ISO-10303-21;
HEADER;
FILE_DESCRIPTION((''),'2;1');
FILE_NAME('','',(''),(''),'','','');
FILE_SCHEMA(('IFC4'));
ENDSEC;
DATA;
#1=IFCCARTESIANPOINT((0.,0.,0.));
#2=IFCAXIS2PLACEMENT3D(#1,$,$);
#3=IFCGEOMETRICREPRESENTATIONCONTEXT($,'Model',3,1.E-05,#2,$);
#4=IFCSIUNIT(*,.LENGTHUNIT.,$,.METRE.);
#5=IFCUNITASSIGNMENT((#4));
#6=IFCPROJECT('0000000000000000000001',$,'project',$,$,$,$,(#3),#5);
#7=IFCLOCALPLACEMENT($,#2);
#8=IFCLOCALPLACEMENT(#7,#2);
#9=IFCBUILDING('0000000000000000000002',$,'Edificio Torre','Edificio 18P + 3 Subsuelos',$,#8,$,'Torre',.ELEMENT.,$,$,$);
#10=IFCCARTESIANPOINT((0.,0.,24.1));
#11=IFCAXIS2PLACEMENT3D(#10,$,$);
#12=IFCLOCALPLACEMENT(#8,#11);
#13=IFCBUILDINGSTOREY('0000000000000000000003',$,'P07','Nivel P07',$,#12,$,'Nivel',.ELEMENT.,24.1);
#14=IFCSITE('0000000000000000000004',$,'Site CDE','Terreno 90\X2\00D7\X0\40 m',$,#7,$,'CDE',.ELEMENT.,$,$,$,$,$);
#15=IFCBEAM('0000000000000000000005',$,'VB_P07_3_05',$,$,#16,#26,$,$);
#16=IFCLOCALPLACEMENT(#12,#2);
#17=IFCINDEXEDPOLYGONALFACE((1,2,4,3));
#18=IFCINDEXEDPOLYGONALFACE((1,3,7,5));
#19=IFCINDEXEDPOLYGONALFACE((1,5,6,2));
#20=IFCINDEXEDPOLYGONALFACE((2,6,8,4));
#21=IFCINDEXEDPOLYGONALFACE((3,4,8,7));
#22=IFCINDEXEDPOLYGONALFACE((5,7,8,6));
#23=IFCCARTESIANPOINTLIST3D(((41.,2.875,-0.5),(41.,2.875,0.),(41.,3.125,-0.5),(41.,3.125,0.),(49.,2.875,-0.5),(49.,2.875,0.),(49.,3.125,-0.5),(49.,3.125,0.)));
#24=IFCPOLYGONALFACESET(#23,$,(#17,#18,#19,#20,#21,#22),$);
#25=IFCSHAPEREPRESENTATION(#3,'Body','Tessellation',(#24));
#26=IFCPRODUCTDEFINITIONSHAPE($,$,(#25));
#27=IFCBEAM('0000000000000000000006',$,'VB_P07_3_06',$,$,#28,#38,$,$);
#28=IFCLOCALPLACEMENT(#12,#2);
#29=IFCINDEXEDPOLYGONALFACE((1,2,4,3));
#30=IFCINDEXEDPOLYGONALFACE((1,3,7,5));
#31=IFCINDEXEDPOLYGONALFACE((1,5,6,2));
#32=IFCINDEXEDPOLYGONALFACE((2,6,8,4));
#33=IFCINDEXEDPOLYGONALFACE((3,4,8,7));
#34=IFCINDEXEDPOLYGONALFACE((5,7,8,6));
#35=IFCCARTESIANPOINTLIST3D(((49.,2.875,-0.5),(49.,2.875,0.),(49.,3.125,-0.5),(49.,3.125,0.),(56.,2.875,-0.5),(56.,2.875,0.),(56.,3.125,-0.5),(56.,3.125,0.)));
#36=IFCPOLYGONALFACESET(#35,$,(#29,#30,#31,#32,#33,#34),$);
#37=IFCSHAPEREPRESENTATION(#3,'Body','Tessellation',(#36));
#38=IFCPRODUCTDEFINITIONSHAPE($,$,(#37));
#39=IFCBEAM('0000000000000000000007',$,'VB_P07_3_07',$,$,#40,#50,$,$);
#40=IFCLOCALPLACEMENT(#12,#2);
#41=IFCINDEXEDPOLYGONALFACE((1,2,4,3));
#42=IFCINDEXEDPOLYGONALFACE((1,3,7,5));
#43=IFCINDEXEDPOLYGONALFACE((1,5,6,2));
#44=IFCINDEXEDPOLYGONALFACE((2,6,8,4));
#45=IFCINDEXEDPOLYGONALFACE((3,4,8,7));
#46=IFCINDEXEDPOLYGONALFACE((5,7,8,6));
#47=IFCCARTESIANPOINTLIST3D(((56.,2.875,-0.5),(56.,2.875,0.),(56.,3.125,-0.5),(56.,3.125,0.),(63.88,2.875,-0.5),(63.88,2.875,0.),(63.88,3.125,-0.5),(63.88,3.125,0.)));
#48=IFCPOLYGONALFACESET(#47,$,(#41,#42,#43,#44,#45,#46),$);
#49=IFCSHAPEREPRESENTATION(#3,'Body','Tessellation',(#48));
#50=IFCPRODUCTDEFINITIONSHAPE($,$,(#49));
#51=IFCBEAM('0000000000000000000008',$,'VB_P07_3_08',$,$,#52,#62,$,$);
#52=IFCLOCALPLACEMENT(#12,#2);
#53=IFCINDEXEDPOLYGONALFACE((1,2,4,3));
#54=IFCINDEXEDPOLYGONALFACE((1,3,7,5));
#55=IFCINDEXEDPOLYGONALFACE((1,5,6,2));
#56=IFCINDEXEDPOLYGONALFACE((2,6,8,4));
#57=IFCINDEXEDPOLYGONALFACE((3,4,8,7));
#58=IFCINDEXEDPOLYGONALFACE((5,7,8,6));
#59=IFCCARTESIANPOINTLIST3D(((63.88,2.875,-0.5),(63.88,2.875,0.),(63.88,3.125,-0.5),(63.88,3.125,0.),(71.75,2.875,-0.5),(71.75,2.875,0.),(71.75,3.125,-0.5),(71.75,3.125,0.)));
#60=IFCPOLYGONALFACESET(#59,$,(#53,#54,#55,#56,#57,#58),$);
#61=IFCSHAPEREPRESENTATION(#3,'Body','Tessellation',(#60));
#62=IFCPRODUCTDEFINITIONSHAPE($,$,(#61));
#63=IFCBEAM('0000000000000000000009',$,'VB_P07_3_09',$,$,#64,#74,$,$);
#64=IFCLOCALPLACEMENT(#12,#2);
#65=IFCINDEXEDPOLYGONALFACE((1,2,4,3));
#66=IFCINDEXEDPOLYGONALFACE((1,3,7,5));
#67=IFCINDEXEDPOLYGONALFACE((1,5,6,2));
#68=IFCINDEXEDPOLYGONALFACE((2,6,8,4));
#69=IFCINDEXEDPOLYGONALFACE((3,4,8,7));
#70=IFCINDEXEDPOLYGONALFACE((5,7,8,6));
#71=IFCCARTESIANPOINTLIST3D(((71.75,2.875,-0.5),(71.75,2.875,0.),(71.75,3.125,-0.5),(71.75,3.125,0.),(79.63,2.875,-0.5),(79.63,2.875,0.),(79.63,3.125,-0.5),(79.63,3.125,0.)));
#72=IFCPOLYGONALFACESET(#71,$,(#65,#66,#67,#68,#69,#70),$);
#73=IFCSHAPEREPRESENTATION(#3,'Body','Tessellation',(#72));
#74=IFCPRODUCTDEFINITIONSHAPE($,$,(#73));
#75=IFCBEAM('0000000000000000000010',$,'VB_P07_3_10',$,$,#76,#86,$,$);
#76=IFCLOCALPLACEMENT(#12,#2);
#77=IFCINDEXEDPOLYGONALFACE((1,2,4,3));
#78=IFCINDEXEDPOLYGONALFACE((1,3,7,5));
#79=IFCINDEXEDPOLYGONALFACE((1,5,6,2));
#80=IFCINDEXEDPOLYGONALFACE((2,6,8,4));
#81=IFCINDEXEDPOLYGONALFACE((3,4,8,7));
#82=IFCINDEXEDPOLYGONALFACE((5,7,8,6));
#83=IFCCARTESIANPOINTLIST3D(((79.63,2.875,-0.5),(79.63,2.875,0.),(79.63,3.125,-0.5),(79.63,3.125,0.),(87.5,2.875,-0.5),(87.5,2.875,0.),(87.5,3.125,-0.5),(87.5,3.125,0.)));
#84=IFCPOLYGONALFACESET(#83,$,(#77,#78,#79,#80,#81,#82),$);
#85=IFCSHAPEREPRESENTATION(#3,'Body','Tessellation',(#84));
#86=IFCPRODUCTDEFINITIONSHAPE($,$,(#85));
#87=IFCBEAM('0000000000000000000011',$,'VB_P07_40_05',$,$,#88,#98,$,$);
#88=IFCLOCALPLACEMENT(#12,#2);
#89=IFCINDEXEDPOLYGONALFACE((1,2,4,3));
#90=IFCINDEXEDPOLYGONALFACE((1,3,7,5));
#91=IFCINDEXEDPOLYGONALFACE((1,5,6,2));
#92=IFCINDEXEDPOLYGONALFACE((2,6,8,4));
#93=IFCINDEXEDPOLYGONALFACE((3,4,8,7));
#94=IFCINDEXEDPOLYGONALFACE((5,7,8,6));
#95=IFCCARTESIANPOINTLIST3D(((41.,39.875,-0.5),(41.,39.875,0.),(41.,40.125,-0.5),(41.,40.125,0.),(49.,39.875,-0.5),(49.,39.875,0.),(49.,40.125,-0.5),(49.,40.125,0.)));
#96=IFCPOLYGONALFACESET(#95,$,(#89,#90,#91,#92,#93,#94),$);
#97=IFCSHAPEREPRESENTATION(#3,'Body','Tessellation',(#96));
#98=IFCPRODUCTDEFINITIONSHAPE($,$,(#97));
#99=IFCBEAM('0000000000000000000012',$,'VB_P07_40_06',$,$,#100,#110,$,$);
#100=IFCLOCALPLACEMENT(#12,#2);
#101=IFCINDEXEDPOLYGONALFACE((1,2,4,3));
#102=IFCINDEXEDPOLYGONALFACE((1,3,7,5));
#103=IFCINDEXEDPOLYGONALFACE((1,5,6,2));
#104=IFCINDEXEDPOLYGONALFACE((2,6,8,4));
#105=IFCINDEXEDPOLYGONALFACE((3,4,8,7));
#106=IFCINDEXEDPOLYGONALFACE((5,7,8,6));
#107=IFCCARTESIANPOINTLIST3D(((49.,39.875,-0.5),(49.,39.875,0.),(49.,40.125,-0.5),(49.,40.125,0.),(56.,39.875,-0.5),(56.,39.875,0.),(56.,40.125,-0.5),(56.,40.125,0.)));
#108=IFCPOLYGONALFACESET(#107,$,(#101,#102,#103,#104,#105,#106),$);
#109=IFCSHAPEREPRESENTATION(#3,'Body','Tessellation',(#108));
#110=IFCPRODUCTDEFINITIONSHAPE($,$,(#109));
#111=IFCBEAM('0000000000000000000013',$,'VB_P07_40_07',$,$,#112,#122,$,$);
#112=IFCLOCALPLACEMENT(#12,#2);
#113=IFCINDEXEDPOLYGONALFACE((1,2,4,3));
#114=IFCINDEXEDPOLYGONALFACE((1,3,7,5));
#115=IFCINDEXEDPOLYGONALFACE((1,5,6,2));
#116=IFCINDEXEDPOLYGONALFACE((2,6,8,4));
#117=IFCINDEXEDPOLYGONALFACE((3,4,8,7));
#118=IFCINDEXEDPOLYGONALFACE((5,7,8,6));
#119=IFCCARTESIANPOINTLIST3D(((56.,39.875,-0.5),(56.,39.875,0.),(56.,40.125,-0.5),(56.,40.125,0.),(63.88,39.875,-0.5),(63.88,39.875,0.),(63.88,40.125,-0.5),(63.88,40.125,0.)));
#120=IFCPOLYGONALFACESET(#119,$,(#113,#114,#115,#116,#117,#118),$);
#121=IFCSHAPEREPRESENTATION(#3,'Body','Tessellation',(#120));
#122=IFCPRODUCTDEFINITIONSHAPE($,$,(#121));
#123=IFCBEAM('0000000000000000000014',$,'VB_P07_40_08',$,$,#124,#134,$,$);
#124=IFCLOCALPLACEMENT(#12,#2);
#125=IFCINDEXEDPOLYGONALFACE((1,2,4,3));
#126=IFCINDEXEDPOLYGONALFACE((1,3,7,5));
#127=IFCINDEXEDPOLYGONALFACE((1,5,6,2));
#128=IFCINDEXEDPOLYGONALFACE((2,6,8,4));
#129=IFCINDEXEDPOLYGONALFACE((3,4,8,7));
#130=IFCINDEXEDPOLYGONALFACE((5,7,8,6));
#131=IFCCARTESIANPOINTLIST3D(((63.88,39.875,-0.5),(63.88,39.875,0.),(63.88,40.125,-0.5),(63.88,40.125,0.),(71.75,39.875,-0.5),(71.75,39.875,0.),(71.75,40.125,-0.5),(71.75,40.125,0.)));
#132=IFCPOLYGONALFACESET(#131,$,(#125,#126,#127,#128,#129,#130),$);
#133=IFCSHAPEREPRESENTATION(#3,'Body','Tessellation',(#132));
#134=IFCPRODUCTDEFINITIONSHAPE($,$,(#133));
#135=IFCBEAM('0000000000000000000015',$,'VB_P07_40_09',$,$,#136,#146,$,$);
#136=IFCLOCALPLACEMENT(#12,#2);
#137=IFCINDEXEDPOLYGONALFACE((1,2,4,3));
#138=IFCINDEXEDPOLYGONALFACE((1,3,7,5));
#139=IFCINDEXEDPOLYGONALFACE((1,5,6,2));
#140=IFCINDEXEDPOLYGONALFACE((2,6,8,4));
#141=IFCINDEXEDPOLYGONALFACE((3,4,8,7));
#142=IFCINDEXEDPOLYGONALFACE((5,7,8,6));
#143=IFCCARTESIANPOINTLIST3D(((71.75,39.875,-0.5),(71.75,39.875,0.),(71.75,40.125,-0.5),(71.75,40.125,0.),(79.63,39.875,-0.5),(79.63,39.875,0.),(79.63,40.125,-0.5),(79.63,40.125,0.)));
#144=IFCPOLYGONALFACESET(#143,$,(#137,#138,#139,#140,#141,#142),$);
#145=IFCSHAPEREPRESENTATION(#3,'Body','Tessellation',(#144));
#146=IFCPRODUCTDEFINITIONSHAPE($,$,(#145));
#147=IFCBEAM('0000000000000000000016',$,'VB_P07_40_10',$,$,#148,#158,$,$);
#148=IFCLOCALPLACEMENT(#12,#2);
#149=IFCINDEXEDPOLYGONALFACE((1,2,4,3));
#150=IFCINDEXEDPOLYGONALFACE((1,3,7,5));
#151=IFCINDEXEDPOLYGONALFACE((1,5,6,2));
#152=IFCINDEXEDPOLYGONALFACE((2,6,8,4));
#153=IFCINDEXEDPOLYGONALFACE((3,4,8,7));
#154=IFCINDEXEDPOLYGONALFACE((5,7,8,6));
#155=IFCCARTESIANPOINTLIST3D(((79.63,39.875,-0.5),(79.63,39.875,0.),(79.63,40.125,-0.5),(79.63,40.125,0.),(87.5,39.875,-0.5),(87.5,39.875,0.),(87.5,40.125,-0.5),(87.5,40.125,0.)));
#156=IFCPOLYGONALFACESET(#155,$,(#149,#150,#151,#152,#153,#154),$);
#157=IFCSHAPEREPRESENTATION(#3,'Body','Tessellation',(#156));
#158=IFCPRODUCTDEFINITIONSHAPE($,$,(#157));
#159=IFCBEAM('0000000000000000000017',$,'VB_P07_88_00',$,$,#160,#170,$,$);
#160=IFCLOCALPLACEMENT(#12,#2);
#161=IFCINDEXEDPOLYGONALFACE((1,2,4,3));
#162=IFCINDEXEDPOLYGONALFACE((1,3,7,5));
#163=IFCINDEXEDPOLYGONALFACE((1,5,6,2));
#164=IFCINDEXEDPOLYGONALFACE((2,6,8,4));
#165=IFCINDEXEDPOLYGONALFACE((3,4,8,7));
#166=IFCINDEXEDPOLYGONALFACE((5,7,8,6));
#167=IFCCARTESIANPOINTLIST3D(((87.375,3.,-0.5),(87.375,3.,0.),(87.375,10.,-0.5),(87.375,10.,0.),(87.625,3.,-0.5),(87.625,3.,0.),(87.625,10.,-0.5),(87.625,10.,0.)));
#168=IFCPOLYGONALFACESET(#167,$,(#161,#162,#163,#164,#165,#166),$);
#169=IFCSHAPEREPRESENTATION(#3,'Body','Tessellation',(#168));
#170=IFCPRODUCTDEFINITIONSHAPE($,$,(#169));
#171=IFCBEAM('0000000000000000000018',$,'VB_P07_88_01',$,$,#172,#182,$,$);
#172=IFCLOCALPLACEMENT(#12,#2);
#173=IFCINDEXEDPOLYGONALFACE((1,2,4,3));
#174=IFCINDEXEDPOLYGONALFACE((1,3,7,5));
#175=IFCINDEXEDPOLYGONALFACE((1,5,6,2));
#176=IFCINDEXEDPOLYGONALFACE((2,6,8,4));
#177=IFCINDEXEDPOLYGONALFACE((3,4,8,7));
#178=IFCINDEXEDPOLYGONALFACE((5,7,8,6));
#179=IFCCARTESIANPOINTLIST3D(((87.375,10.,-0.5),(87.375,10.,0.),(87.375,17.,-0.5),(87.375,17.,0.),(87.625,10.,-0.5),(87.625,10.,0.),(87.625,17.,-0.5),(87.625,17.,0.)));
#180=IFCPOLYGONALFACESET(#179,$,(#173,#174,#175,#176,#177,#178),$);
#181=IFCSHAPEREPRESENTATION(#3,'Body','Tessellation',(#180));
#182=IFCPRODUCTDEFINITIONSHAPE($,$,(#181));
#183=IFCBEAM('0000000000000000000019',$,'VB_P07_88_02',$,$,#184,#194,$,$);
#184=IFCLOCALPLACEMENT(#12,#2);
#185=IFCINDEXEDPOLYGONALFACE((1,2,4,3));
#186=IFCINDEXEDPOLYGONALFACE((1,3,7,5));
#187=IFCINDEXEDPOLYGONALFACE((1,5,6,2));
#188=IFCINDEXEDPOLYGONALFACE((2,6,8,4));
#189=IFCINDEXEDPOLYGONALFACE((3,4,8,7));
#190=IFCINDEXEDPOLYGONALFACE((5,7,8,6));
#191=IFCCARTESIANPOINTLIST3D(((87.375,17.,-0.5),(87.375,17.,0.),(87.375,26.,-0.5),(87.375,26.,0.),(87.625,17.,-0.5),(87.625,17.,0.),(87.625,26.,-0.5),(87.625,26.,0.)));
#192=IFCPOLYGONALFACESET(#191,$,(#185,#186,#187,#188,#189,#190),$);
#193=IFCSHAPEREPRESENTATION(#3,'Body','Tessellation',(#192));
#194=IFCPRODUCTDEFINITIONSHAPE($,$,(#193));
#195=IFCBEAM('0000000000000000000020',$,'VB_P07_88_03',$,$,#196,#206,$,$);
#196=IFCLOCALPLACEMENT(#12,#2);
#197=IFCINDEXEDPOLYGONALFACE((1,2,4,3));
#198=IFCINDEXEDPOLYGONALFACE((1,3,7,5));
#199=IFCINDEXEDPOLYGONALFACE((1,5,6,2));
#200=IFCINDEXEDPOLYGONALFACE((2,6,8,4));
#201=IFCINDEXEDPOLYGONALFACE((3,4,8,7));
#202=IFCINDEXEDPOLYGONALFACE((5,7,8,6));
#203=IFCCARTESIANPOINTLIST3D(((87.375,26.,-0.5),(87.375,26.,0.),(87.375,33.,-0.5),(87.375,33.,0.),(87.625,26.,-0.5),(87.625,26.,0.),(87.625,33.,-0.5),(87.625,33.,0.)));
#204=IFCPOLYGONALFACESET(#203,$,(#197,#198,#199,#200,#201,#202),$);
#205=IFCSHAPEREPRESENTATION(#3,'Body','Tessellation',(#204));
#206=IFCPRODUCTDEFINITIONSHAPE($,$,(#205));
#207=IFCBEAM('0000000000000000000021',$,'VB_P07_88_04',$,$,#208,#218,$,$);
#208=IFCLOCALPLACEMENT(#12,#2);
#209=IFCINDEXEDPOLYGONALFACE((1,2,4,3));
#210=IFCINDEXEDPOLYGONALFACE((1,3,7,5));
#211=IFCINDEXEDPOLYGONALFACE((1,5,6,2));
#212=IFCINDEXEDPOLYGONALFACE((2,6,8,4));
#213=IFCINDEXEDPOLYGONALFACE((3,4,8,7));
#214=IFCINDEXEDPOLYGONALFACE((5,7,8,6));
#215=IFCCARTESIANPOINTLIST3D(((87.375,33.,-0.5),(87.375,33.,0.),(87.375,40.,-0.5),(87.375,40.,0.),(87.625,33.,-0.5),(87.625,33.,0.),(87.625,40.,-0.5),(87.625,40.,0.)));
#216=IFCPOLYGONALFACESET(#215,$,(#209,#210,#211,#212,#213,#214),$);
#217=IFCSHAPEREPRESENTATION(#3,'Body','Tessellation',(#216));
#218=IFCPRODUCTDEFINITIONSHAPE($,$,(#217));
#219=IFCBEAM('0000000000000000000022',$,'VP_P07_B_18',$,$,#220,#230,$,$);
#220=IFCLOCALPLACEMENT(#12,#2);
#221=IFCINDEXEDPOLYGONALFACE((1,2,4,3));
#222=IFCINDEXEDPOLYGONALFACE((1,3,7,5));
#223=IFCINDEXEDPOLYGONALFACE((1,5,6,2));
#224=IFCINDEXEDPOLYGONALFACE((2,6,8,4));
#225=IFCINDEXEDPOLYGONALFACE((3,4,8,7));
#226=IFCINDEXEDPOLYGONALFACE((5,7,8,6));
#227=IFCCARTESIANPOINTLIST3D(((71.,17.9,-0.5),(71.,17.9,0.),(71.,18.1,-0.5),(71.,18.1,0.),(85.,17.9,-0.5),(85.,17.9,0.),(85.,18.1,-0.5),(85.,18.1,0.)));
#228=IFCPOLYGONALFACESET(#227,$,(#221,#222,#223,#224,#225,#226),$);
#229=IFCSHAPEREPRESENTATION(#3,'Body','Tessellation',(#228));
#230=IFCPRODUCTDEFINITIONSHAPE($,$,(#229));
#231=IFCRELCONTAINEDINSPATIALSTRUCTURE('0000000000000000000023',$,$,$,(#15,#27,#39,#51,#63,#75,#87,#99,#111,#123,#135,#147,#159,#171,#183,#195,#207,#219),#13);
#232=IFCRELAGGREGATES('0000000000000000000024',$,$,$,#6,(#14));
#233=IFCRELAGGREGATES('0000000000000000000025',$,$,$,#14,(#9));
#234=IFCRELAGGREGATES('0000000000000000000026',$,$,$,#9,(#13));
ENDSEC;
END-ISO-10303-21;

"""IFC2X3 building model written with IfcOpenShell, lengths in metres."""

from ifc_helpers import new_model, si_unit, frame, origin, origin_2d, place, context, project, spatial, rectangle, extrude, element, save


model = new_model("IFC2X3")

# Units and contexts
model_context = context("Model", 3, precision=1e-05, world=origin())
ifc_project = project(units=[si_unit("LENGTHUNIT", "METRE")], contexts=[model_context])

# Site, building, storey
site_placement = place(None, origin())
site = spatial("IfcSite", under=ifc_project, at=site_placement, Name="Site CDE", Description="Terreno 90×40 m", LongName="CDE", CompositionType="ELEMENT")
building_placement = place(site_placement, origin())
building = spatial("IfcBuilding", under=site, at=building_placement, Name="Edificio Torre", Description="Edificio 18P + 3 Subsuelos", LongName="Torre", CompositionType="ELEMENT")
storey_placement = place(building_placement, frame((0.0, 0.0, 24.1)))
storey = spatial("IfcBuildingStorey", under=building, at=storey_placement, Name="P07", Description="Nivel P07", LongName="Nivel", CompositionType="ELEMENT", Elevation=24.1)

# Beams
beam_1_placement = place(storey_placement, frame((45.0, 3.0, -0.5)))
element("IfcBeam", 1, at=beam_1_placement, inside=storey, Name="VB_P07_3_05", context=model_context, shape_type="SweptSolid", body=[
    extrude(rectangle(XDim=8.0, YDim=0.25, at=origin_2d()), origin(), (0.0, 0.0, 1.0), 0.5),
])
beam_2_placement = place(storey_placement, frame((52.5, 3.0, -0.5)))
element("IfcBeam", 2, at=beam_2_placement, inside=storey, Name="VB_P07_3_06", context=model_context, shape_type="SweptSolid", body=[
    extrude(rectangle(XDim=7.0, YDim=0.25, at=origin_2d()), origin(), (0.0, 0.0, 1.0), 0.5),
])
beam_3_placement = place(storey_placement, frame((59.94, 3.0, -0.5)))
element("IfcBeam", 3, at=beam_3_placement, inside=storey, Name="VB_P07_3_07", context=model_context, shape_type="SweptSolid", body=[
    extrude(rectangle(XDim=7.88, YDim=0.25, at=origin_2d()), origin(), (0.0, 0.0, 1.0), 0.5),
])
beam_4_placement = place(storey_placement, frame((67.815, 3.0, -0.5)))
element("IfcBeam", 4, at=beam_4_placement, inside=storey, Name="VB_P07_3_08", context=model_context, shape_type="SweptSolid", body=[
    extrude(rectangle(XDim=7.87, YDim=0.25, at=origin_2d()), origin(), (0.0, 0.0, 1.0), 0.5),
])
beam_5_placement = place(storey_placement, frame((75.69, 3.0, -0.5)))
element("IfcBeam", 5, at=beam_5_placement, inside=storey, Name="VB_P07_3_09", context=model_context, shape_type="SweptSolid", body=[
    extrude(rectangle(XDim=7.88, YDim=0.25, at=origin_2d()), origin(), (0.0, 0.0, 1.0), 0.5),
])
beam_6_placement = place(storey_placement, frame((83.565, 3.0, -0.5)))
element("IfcBeam", 6, at=beam_6_placement, inside=storey, Name="VB_P07_3_10", context=model_context, shape_type="SweptSolid", body=[
    extrude(rectangle(XDim=7.87, YDim=0.25, at=origin_2d()), origin(), (0.0, 0.0, 1.0), 0.5),
])
beam_7_placement = place(storey_placement, frame((45.0, 40.0, -0.5)))
element("IfcBeam", 7, at=beam_7_placement, inside=storey, Name="VB_P07_40_05", context=model_context, shape_type="SweptSolid", body=[
    extrude(rectangle(XDim=8.0, YDim=0.25, at=origin_2d()), origin(), (0.0, 0.0, 1.0), 0.5),
])
beam_8_placement = place(storey_placement, frame((52.5, 40.0, -0.5)))
element("IfcBeam", 8, at=beam_8_placement, inside=storey, Name="VB_P07_40_06", context=model_context, shape_type="SweptSolid", body=[
    extrude(rectangle(XDim=7.0, YDim=0.25, at=origin_2d()), origin(), (0.0, 0.0, 1.0), 0.5),
])
beam_9_placement = place(storey_placement, frame((59.94, 40.0, -0.5)))
element("IfcBeam", 9, at=beam_9_placement, inside=storey, Name="VB_P07_40_07", context=model_context, shape_type="SweptSolid", body=[
    extrude(rectangle(XDim=7.88, YDim=0.25, at=origin_2d()), origin(), (0.0, 0.0, 1.0), 0.5),
])
beam_10_placement = place(storey_placement, frame((67.815, 40.0, -0.5)))
element("IfcBeam", 10, at=beam_10_placement, inside=storey, Name="VB_P07_40_08", context=model_context, shape_type="SweptSolid", body=[
    extrude(rectangle(XDim=7.87, YDim=0.25, at=origin_2d()), origin(), (0.0, 0.0, 1.0), 0.5),
])
beam_11_placement = place(storey_placement, frame((75.69, 40.0, -0.5)))
element("IfcBeam", 11, at=beam_11_placement, inside=storey, Name="VB_P07_40_09", context=model_context, shape_type="SweptSolid", body=[
    extrude(rectangle(XDim=7.88, YDim=0.25, at=origin_2d()), origin(), (0.0, 0.0, 1.0), 0.5),
])
beam_12_placement = place(storey_placement, frame((83.565, 40.0, -0.5)))
element("IfcBeam", 12, at=beam_12_placement, inside=storey, Name="VB_P07_40_10", context=model_context, shape_type="SweptSolid", body=[
    extrude(rectangle(XDim=7.87, YDim=0.25, at=origin_2d()), origin(), (0.0, 0.0, 1.0), 0.5),
])
for number, where, name in (
    (13, (87.5, 6.5, -0.5), "VB_P07_88_00"),
    (14, (87.5, 13.5, -0.5), "VB_P07_88_01"),
):
    element("IfcBeam", number, at=place(storey_placement, frame(where)), inside=storey, Name=name, context=model_context, shape_type="SweptSolid", body=[
        extrude(rectangle(XDim=0.25, YDim=7.0, at=origin_2d()), origin(), (0.0, 0.0, 1.0), 0.5),
    ])
beam_13_placement = place(storey_placement, frame((87.5, 21.5, -0.5)))
element("IfcBeam", 15, at=beam_13_placement, inside=storey, Name="VB_P07_88_02", context=model_context, shape_type="SweptSolid", body=[
    extrude(rectangle(XDim=0.25, YDim=9.0, at=origin_2d()), origin(), (0.0, 0.0, 1.0), 0.5),
])
for number, where, name in (
    (16, (87.5, 29.5, -0.5), "VB_P07_88_03"),
    (17, (87.5, 36.5, -0.5), "VB_P07_88_04"),
):
    element("IfcBeam", number, at=place(storey_placement, frame(where)), inside=storey, Name=name, context=model_context, shape_type="SweptSolid", body=[
        extrude(rectangle(XDim=0.25, YDim=7.0, at=origin_2d()), origin(), (0.0, 0.0, 1.0), 0.5),
    ])
for number, where, name in (
    (18, (78.0, 18.0, -0.5), "VP_P07_B_18"),
):
    element("IfcBeam", number, at=place(storey_placement, frame(where)), inside=storey, Name=name, context=model_context, shape_type="SweptSolid", body=[
        extrude(rectangle(XDim=14.0, YDim=0.2, at=origin_2d()), origin(), (0.0, 0.0, 1.0), 0.5),
    ])

save(model, "model.ifc")
